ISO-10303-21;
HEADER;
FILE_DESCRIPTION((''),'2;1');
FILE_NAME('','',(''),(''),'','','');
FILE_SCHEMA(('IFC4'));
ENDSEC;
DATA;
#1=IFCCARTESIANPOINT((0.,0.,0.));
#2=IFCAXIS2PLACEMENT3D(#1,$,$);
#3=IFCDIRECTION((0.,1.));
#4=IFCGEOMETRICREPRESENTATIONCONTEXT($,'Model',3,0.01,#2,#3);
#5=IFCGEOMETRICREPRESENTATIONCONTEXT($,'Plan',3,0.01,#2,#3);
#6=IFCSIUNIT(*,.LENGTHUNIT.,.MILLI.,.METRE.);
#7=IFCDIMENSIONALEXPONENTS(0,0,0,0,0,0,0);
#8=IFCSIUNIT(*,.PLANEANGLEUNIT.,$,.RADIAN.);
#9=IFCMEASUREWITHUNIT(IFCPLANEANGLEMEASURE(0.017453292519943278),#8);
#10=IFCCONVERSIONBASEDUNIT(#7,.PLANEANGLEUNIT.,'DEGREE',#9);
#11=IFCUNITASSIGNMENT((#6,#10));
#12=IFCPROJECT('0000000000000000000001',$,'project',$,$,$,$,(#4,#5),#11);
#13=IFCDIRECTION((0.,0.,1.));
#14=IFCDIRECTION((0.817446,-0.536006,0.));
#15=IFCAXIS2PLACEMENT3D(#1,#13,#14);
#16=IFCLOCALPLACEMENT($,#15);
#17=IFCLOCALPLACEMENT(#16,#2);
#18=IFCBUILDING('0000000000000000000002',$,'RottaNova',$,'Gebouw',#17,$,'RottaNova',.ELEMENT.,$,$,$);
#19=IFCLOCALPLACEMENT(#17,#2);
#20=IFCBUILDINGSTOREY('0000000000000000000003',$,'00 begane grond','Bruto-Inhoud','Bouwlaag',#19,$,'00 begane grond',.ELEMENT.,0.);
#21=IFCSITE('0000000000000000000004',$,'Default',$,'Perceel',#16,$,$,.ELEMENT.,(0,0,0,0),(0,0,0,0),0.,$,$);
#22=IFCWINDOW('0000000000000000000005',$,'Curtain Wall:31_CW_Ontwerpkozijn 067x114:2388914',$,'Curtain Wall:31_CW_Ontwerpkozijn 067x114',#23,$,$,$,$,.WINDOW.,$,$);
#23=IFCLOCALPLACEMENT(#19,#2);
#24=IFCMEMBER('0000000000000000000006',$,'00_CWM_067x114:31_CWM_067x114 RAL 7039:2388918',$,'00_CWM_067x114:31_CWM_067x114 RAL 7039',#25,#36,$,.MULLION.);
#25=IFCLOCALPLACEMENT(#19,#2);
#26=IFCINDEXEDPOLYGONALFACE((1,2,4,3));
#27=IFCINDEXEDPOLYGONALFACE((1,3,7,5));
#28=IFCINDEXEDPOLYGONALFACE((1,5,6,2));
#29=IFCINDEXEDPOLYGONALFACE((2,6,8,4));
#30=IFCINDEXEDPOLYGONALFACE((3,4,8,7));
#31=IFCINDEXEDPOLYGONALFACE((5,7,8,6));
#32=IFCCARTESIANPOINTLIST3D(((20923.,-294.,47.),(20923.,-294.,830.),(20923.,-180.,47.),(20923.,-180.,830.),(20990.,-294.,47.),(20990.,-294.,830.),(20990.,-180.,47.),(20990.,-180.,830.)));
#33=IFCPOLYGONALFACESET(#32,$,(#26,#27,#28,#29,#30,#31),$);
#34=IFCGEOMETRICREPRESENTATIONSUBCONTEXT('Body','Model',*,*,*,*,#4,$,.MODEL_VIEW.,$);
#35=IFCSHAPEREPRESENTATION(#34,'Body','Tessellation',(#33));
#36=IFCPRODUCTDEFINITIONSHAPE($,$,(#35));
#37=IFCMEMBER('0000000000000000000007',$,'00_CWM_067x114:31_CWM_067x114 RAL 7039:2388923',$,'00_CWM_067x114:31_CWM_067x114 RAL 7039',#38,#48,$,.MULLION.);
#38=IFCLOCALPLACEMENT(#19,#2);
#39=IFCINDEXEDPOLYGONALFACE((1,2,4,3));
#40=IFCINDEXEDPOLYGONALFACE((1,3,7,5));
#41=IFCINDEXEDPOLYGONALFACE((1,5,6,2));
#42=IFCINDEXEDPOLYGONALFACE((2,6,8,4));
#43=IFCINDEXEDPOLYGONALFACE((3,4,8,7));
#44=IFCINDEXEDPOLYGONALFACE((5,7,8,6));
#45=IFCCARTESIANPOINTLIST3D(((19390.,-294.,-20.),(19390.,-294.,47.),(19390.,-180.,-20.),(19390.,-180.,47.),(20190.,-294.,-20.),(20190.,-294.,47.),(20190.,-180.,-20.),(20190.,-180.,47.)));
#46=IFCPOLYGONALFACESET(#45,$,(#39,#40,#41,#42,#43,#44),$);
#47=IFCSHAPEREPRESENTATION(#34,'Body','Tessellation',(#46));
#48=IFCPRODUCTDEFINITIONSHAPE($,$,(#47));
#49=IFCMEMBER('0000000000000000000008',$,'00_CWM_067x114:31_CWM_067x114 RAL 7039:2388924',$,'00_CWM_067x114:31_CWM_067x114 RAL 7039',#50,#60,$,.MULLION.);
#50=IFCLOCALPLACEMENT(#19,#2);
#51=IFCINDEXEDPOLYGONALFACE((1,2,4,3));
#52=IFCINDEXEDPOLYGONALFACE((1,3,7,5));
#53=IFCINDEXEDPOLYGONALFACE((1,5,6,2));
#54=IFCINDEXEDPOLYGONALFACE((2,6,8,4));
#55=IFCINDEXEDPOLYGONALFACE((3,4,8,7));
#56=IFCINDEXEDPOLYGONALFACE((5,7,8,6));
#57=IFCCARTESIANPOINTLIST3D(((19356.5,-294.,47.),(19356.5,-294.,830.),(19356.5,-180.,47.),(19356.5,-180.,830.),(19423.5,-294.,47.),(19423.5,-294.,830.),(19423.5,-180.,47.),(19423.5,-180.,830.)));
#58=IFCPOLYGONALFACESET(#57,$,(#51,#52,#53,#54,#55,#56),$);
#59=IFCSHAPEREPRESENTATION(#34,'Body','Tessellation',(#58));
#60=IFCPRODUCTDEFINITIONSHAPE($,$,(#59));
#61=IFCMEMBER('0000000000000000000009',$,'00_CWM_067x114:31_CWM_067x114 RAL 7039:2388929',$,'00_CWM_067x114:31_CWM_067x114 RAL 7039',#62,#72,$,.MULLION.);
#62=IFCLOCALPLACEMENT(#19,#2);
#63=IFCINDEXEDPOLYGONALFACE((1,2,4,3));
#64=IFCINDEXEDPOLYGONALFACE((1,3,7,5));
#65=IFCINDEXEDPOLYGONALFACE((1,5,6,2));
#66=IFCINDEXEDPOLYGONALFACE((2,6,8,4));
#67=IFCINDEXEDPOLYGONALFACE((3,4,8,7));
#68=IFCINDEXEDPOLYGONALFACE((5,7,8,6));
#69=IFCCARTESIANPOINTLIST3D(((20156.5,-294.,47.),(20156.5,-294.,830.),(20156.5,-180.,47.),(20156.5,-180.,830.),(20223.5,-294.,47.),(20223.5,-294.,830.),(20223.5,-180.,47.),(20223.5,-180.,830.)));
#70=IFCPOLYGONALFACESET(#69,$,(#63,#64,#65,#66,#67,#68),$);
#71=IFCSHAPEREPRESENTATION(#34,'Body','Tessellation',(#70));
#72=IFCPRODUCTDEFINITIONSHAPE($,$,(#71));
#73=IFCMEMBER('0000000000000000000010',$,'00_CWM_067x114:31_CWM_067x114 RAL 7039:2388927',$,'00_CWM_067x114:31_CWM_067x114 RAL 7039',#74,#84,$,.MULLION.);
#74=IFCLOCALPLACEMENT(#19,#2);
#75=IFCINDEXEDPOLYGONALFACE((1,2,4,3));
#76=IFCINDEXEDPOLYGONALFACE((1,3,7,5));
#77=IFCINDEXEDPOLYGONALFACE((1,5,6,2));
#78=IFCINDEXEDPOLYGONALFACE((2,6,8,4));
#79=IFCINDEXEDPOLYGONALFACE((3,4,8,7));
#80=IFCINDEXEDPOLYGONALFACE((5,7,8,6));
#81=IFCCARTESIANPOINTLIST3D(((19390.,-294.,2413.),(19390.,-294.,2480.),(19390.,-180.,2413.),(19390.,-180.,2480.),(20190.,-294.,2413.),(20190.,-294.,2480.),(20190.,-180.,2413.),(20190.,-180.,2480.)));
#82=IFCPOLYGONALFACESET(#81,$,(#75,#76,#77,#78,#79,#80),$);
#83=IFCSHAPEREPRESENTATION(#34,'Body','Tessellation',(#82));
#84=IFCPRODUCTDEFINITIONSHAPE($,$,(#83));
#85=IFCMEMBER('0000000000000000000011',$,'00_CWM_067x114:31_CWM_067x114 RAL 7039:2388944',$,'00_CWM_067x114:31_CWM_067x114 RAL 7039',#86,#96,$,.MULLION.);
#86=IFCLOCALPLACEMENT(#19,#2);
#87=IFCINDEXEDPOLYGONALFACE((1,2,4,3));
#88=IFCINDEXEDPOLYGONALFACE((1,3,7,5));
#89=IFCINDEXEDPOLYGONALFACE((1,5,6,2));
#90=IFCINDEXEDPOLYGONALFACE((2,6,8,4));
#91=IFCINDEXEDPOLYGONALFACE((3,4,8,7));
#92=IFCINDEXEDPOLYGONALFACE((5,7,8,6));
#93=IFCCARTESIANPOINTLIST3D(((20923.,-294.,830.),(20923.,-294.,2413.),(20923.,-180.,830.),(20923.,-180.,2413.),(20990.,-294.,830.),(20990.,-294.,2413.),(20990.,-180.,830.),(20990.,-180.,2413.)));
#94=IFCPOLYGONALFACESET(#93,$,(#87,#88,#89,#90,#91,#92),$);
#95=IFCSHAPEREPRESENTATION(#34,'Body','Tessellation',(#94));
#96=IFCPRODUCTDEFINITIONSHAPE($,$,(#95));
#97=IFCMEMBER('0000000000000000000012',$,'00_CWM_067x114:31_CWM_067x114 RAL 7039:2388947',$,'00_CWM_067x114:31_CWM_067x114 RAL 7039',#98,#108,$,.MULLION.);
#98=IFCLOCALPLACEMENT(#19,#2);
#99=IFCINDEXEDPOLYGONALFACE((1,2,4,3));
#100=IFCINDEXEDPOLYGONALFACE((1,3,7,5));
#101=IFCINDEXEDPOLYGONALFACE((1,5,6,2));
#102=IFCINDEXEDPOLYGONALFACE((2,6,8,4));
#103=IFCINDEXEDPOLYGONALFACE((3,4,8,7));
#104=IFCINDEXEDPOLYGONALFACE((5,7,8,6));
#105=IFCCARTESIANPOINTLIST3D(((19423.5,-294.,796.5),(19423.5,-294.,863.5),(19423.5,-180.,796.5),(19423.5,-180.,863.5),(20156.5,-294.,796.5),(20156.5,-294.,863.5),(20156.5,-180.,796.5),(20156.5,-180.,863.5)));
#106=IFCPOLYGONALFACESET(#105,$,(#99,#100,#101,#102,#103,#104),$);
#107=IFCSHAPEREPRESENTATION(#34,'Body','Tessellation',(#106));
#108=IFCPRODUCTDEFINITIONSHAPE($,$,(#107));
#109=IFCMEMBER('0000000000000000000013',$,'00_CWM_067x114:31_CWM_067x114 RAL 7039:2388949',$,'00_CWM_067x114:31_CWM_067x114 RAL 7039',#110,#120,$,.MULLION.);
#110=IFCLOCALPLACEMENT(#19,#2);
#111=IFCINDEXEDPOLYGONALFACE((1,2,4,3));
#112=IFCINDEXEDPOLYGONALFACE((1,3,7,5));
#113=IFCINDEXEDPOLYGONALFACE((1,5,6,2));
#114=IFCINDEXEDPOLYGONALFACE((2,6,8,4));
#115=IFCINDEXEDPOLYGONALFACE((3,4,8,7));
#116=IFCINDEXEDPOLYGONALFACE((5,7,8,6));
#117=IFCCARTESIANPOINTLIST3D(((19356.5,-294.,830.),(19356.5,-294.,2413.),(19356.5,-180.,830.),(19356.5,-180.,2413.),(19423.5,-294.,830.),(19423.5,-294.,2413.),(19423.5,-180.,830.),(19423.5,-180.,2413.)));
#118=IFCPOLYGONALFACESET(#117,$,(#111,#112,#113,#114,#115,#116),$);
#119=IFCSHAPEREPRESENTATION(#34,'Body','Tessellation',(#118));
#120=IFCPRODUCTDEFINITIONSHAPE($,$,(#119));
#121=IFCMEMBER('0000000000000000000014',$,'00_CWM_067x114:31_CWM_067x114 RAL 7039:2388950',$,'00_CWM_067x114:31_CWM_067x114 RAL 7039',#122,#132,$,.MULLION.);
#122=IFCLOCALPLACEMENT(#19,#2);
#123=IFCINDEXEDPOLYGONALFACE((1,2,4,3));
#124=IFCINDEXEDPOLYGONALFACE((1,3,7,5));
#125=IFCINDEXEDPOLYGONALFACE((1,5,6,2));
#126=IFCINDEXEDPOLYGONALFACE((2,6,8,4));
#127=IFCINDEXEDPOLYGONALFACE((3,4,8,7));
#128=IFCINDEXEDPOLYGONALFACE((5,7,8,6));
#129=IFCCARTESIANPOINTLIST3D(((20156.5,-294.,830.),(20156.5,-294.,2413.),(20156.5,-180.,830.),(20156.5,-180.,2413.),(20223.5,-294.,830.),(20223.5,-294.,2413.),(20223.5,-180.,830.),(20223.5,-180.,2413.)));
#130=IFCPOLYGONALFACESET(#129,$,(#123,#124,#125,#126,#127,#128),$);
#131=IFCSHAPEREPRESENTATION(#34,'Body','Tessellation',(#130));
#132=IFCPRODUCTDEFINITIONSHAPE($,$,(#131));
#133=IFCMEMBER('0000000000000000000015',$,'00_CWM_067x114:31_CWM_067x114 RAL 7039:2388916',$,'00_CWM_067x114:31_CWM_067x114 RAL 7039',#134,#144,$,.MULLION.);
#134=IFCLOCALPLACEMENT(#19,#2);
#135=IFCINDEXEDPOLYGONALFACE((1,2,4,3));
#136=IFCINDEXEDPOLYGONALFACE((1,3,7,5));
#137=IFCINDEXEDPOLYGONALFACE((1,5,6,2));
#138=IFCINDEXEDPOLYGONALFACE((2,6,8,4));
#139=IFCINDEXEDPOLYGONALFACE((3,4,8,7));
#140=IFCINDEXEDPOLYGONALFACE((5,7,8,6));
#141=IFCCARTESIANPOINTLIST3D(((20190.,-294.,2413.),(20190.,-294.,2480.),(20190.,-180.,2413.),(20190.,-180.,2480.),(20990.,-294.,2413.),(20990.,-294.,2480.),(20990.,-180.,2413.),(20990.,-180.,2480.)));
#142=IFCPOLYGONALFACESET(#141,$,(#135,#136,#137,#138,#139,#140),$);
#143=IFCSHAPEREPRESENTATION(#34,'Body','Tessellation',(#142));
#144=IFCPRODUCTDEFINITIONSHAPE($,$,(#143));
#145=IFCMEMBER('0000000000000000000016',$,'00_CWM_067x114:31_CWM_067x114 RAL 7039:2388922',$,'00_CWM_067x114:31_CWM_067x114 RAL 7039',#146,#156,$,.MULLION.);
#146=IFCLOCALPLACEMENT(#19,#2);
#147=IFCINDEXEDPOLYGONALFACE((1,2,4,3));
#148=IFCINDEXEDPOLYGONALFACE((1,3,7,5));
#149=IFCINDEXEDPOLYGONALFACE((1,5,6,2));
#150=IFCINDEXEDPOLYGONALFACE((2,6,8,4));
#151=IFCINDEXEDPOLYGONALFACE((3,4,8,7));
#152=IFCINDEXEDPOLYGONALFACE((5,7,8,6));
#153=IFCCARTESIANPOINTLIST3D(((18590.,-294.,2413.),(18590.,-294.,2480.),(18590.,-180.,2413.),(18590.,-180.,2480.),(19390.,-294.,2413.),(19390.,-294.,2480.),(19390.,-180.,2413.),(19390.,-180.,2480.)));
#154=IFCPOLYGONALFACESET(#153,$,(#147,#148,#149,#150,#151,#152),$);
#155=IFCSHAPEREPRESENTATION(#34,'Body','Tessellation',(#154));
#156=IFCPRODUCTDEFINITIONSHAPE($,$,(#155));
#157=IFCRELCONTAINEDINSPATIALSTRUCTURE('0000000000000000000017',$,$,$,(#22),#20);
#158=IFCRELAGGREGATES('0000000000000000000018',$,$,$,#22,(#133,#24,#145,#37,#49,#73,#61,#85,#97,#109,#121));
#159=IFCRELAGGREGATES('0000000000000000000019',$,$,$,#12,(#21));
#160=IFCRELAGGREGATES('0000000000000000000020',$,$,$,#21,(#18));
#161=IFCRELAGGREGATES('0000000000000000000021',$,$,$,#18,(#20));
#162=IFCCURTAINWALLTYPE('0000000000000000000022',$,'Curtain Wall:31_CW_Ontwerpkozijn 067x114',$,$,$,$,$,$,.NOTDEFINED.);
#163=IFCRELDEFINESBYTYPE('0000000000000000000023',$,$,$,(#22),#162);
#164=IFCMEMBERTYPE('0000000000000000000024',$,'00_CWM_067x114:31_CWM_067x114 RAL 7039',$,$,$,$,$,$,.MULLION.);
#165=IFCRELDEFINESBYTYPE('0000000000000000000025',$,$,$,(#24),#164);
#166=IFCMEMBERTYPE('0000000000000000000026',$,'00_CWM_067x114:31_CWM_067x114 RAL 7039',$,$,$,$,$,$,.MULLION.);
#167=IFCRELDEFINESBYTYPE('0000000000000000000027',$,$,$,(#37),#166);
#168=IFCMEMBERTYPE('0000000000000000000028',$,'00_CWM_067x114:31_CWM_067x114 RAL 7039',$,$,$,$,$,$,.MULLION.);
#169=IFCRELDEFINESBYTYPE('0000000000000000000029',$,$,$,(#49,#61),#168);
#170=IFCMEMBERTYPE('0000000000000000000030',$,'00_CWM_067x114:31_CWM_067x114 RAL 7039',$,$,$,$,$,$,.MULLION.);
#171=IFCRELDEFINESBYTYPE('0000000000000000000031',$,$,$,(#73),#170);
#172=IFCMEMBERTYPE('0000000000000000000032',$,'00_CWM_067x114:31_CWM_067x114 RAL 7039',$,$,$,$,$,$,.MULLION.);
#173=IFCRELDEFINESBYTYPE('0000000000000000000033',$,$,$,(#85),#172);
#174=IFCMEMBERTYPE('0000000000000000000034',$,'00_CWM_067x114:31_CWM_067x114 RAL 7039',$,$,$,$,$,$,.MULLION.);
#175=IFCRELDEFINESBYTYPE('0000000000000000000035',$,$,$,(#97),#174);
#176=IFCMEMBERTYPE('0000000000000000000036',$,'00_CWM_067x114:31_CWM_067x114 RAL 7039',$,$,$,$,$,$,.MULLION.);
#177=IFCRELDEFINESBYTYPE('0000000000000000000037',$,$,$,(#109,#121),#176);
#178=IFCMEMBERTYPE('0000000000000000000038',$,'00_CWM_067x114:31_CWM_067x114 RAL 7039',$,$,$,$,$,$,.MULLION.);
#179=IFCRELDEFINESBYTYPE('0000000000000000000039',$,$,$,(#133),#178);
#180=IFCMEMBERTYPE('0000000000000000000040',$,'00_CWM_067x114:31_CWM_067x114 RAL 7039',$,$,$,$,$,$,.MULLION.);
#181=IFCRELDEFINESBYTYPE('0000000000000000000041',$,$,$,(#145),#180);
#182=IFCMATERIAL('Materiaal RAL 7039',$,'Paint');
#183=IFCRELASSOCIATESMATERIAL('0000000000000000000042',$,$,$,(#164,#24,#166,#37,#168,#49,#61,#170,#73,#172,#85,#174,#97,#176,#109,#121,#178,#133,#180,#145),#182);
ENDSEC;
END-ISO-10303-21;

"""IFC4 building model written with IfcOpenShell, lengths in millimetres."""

from ifc_helpers import new_model, entity, si_unit, converted_unit, direction, frame, origin, place, context, subcontext, project, spatial, indexed_curve, outline, extrude, source, transform, mapped, material, type_object, type_shapes, element, aggregate, save


model = new_model("IFC4")

# Units and contexts
model_context = context("Model", 3, precision=0.01, world=origin(), true_north=direction((0.0, 1.0)))
plan_context = context("Plan", 3, precision=0.01, world=origin(), true_north=direction((0.0, 1.0)))
body_context = subcontext(model_context, "Body", "Model", "MODEL_VIEW")
ifc_project = project(units=[si_unit("LENGTHUNIT", "METRE", prefix="MILLI"), converted_unit("PLANEANGLEUNIT", "DEGREE", entity("IfcPlaneAngleMeasure", 0.017453292519943278), si_unit("PLANEANGLEUNIT", "RADIAN"), dimensions=[0, 0, 0, 0, 0, 0, 0])], contexts=[model_context, plan_context])

# Site, building, storey
site_placement = place(None, frame((0.0, 0.0, 0.0), z_axis=(0.0, 0.0, 1.0), x_axis=(0.817446, -0.536006, 0.0)))
site = spatial("IfcSite", under=ifc_project, at=site_placement, Name="Default", ObjectType="Perceel", CompositionType="ELEMENT", RefLatitude=(0, 0, 0, 0), RefLongitude=(0, 0, 0, 0), RefElevation=0.0)
building_placement = place(site_placement, origin())
building = spatial("IfcBuilding", under=site, at=building_placement, Name="RottaNova", ObjectType="Gebouw", LongName="RottaNova", CompositionType="ELEMENT")
storey_placement = place(building_placement, origin())
storey = spatial("IfcBuildingStorey", under=building, at=storey_placement, Name="00 begane grond", Description="Bruto-Inhoud", ObjectType="Bouwlaag", LongName="00 begane grond", CompositionType="ELEMENT", Elevation=0.0)

# Window, members
curtain_wall_type = type_object("IfcCurtainWallType", Name="Curtain Wall:31_CW_Ontwerpkozijn 067x114", PredefinedType="NOTDEFINED")
window_1_placement = place(storey_placement, origin())
window_1 = element("IfcWindow", 1, at=window_1_placement, inside=storey, type_object=curtain_wall_type, Name="Curtain Wall:31_CW_Ontwerpkozijn 067x114:2388914", ObjectType="Curtain Wall:31_CW_Ontwerpkozijn 067x114", PredefinedType="WINDOW")
ifc_material_1 = material(Name="Materiaal RAL 7039", Category="Paint")
member_type_1 = type_object("IfcMemberType", Name="00_CWM_067x114:31_CWM_067x114 RAL 7039", PredefinedType="MULLION", material=ifc_material_1)
shared_shape_1 = source(origin(), body_context, "Body", "SweptSolid", [
    extrude(outline(indexed_curve([(-33.5, -57.0), (33.5, -57.0), (33.5, 57.0), (-33.5, 57.0), (-33.5, -57.0)], self_intersect=False)), frame((-33.5, 57.0, -783.0), z_axis=(0.0, 0.0, 1.0), x_axis=(-1.0, 0.0, 0.0)), (0.0, 0.0, 1.0), 783.0),
])
type_shapes(member_type_1, [shared_shape_1])
member_1_placement = place(window_1_placement, frame((20990.0, -180.0, 47.0), z_axis=(0.0, 0.0, -1.0), x_axis=(1.0, 0.0, 0.0)))
member_1 = element("IfcMember", 2, at=member_1_placement, type_object=member_type_1, material=ifc_material_1, Name="00_CWM_067x114:31_CWM_067x114 RAL 7039:2388918", ObjectType="00_CWM_067x114:31_CWM_067x114 RAL 7039", PredefinedType="MULLION", context=body_context, shape_type="MappedRepresentation", body=[
    mapped(shared_shape_1, transform((0.0, 0.0, 0.0), scale=1.0)),
])
member_type_2 = type_object("IfcMemberType", Name="00_CWM_067x114:31_CWM_067x114 RAL 7039", PredefinedType="MULLION", material=ifc_material_1)
shared_shape_2 = source(origin(), body_context, "Body", "SweptSolid", [
    extrude(outline(indexed_curve([(-33.5, -57.0), (33.5, -57.0), (33.5, 57.0), (-33.5, 57.0), (-33.5, -57.0)], self_intersect=False)), frame((-33.5, 57.0, -800.0), z_axis=(0.0, 0.0, 1.0), x_axis=(-1.0, 0.0, 0.0)), (0.0, 0.0, 1.0), 800.0),
])
type_shapes(member_type_2, [shared_shape_2])
member_2_placement = place(window_1_placement, frame((19390.0, -180.0, -20.0), z_axis=(-1.0, 0.0, 0.0), x_axis=(0.0, 0.0, -1.0)))
member_2 = element("IfcMember", 3, at=member_2_placement, type_object=member_type_2, material=ifc_material_1, Name="00_CWM_067x114:31_CWM_067x114 RAL 7039:2388923", ObjectType="00_CWM_067x114:31_CWM_067x114 RAL 7039", PredefinedType="MULLION", context=body_context, shape_type="MappedRepresentation", body=[
    mapped(shared_shape_2, transform((0.0, 0.0, 0.0), scale=1.0)),
])
member_type_3 = type_object("IfcMemberType", Name="00_CWM_067x114:31_CWM_067x114 RAL 7039", PredefinedType="MULLION", material=ifc_material_1)
shared_shape_3 = source(origin(), body_context, "Body", "SweptSolid", [
    extrude(outline(indexed_curve([(-33.5, -57.0), (33.5, -57.0), (33.5, 57.0), (-33.5, 57.0), (-33.5, -57.0)], self_intersect=False)), frame((0.0, 57.0, -783.0), z_axis=(0.0, 0.0, 1.0), x_axis=(-1.0, 0.0, 0.0)), (0.0, 0.0, 1.0), 783.0),
])
type_shapes(member_type_3, [shared_shape_3])
member_3_placement = place(window_1_placement, frame((19390.0, -180.0, 47.0), z_axis=(0.0, 0.0, -1.0), x_axis=(1.0, 0.0, 0.0)))
member_3 = element("IfcMember", 4, at=member_3_placement, type_object=member_type_3, material=ifc_material_1, Name="00_CWM_067x114:31_CWM_067x114 RAL 7039:2388924", ObjectType="00_CWM_067x114:31_CWM_067x114 RAL 7039", PredefinedType="MULLION", context=body_context, shape_type="MappedRepresentation", body=[
    mapped(shared_shape_3, transform((0.0, 0.0, 0.0), scale=1.0)),
])
member_4_placement = place(window_1_placement, frame((20190.0, -180.0, 47.0), z_axis=(0.0, 0.0, -1.0), x_axis=(1.0, 0.0, 0.0)))
member_4 = element("IfcMember", 5, at=member_4_placement, type_object=member_type_3, material=ifc_material_1, Name="00_CWM_067x114:31_CWM_067x114 RAL 7039:2388929", ObjectType="00_CWM_067x114:31_CWM_067x114 RAL 7039", PredefinedType="MULLION", context=body_context, shape_type="MappedRepresentation", body=[
    mapped(shared_shape_3, transform((0.0, 0.0, 0.0), scale=1.0)),
])
member_type_4 = type_object("IfcMemberType", Name="00_CWM_067x114:31_CWM_067x114 RAL 7039", PredefinedType="MULLION", material=ifc_material_1)
shared_shape_4 = source(origin(), body_context, "Body", "SweptSolid", [
    extrude(outline(indexed_curve([(-33.5, -57.0), (33.5, -57.0), (33.5, 57.0), (-33.5, 57.0), (-33.5, -57.0)], self_intersect=False)), frame((-33.5, 57.0, -800.0), z_axis=(0.0, 0.0, 1.0), x_axis=(-1.0, 0.0, 0.0)), (0.0, 0.0, 1.0), 800.0),
])
type_shapes(member_type_4, [shared_shape_4])
member_5_placement = place(window_1_placement, frame((20190.0, -180.0, 2480.0), z_axis=(1.0, 0.0, 0.0), x_axis=(0.0, 0.0, 1.0)))
member_5 = element("IfcMember", 6, at=member_5_placement, type_object=member_type_4, material=ifc_material_1, Name="00_CWM_067x114:31_CWM_067x114 RAL 7039:2388927", ObjectType="00_CWM_067x114:31_CWM_067x114 RAL 7039", PredefinedType="MULLION", context=body_context, shape_type="MappedRepresentation", body=[
    mapped(shared_shape_4, transform((0.0, 0.0, 0.0), scale=1.0)),
])
member_type_5 = type_object("IfcMemberType", Name="00_CWM_067x114:31_CWM_067x114 RAL 7039", PredefinedType="MULLION", material=ifc_material_1)
shared_shape_5 = source(origin(), body_context, "Body", "SweptSolid", [
    extrude(outline(indexed_curve([(-33.5, -57.0), (33.5, -57.0), (33.5, 57.0), (-33.5, 57.0), (-33.5, -57.0)], self_intersect=False)), frame((-33.5, 57.0, -1583.0), z_axis=(0.0, 0.0, 1.0), x_axis=(-1.0, 0.0, 0.0)), (0.0, 0.0, 1.0), 1583.0),
])
type_shapes(member_type_5, [shared_shape_5])
member_6_placement = place(window_1_placement, frame((20990.0, -180.0, 830.0), z_axis=(0.0, 0.0, -1.0), x_axis=(1.0, 0.0, 0.0)))
member_6 = element("IfcMember", 7, at=member_6_placement, type_object=member_type_5, material=ifc_material_1, Name="00_CWM_067x114:31_CWM_067x114 RAL 7039:2388944", ObjectType="00_CWM_067x114:31_CWM_067x114 RAL 7039", PredefinedType="MULLION", context=body_context, shape_type="MappedRepresentation", body=[
    mapped(shared_shape_5, transform((0.0, 0.0, 0.0), scale=1.0)),
])
member_type_6 = type_object("IfcMemberType", Name="00_CWM_067x114:31_CWM_067x114 RAL 7039", PredefinedType="MULLION", material=ifc_material_1)
shared_shape_6 = source(origin(), body_context, "Body", "SweptSolid", [
    extrude(outline(indexed_curve([(-33.5, -57.0), (33.5, -57.0), (33.5, 57.0), (-33.5, 57.0), (-33.5, -57.0)], self_intersect=False)), frame((0.0, 57.0, -733.0), z_axis=(0.0, 0.0, 1.0), x_axis=(-1.0, 0.0, 0.0)), (0.0, 0.0, 1.0), 733.0),
])
type_shapes(member_type_6, [shared_shape_6])
member_7_placement = place(window_1_placement, frame((20156.5, -180.0, 830.0), z_axis=(1.0, 0.0, 0.0), x_axis=(0.0, 0.0, 1.0)))
member_7 = element("IfcMember", 8, at=member_7_placement, type_object=member_type_6, material=ifc_material_1, Name="00_CWM_067x114:31_CWM_067x114 RAL 7039:2388947", ObjectType="00_CWM_067x114:31_CWM_067x114 RAL 7039", PredefinedType="MULLION", context=body_context, shape_type="MappedRepresentation", body=[
    mapped(shared_shape_6, transform((0.0, 0.0, 0.0), scale=1.0)),
])
member_type_7 = type_object("IfcMemberType", Name="00_CWM_067x114:31_CWM_067x114 RAL 7039", PredefinedType="MULLION", material=ifc_material_1)
shared_shape_7 = source(origin(), body_context, "Body", "SweptSolid", [
    extrude(outline(indexed_curve([(-33.5, -57.0), (33.5, -57.0), (33.5, 57.0), (-33.5, 57.0), (-33.5, -57.0)], self_intersect=False)), frame((0.0, 57.0, -1583.0), z_axis=(0.0, 0.0, 1.0), x_axis=(-1.0, 0.0, 0.0)), (0.0, 0.0, 1.0), 1583.0),
])
type_shapes(member_type_7, [shared_shape_7])
member_8_placement = place(window_1_placement, frame((19390.0, -180.0, 830.0), z_axis=(0.0, 0.0, -1.0), x_axis=(1.0, 0.0, 0.0)))
member_8 = element("IfcMember", 9, at=member_8_placement, type_object=member_type_7, material=ifc_material_1, Name="00_CWM_067x114:31_CWM_067x114 RAL 7039:2388949", ObjectType="00_CWM_067x114:31_CWM_067x114 RAL 7039", PredefinedType="MULLION", context=body_context, shape_type="MappedRepresentation", body=[
    mapped(shared_shape_7, transform((0.0, 0.0, 0.0), scale=1.0)),
])
member_9_placement = place(window_1_placement, frame((20190.0, -180.0, 830.0), z_axis=(0.0, 0.0, -1.0), x_axis=(1.0, 0.0, 0.0)))
member_9 = element("IfcMember", 10, at=member_9_placement, type_object=member_type_7, material=ifc_material_1, Name="00_CWM_067x114:31_CWM_067x114 RAL 7039:2388950", ObjectType="00_CWM_067x114:31_CWM_067x114 RAL 7039", PredefinedType="MULLION", context=body_context, shape_type="MappedRepresentation", body=[
    mapped(shared_shape_7, transform((0.0, 0.0, 0.0), scale=1.0)),
])
member_type_8 = type_object("IfcMemberType", Name="00_CWM_067x114:31_CWM_067x114 RAL 7039", PredefinedType="MULLION", material=ifc_material_1)
shared_shape_8 = source(origin(), body_context, "Body", "SweptSolid", [
    extrude(outline(indexed_curve([(-33.5, -57.0), (33.5, -57.0), (33.5, 57.0), (-33.5, 57.0), (-33.5, -57.0)], self_intersect=False)), frame((-33.5, 57.0, -800.0), z_axis=(0.0, 0.0, 1.0), x_axis=(-1.0, 0.0, 0.0)), (0.0, 0.0, 1.0), 800.0),
])
type_shapes(member_type_8, [shared_shape_8])
member_10_placement = place(window_1_placement, frame((20990.0, -180.0, 2480.0), z_axis=(1.0, 0.0, 0.0), x_axis=(0.0, 0.0, 1.0)))
member_10 = element("IfcMember", 11, at=member_10_placement, type_object=member_type_8, material=ifc_material_1, Name="00_CWM_067x114:31_CWM_067x114 RAL 7039:2388916", ObjectType="00_CWM_067x114:31_CWM_067x114 RAL 7039", PredefinedType="MULLION", context=body_context, shape_type="MappedRepresentation", body=[
    mapped(shared_shape_8, transform((0.0, 0.0, 0.0), scale=1.0)),
])
member_type_9 = type_object("IfcMemberType", Name="00_CWM_067x114:31_CWM_067x114 RAL 7039", PredefinedType="MULLION", material=ifc_material_1)
shared_shape_9 = source(origin(), body_context, "Body", "SweptSolid", [
    extrude(outline(indexed_curve([(-33.5, -57.0), (33.5, -57.0), (33.5, 57.0), (-33.5, 57.0), (-33.5, -57.0)], self_intersect=False)), frame((-33.5, 57.0, -800.0), z_axis=(0.0, 0.0, 1.0), x_axis=(-1.0, 0.0, 0.0)), (0.0, 0.0, 1.0), 800.0),
])
type_shapes(member_type_9, [shared_shape_9])
member_11_placement = place(window_1_placement, frame((19390.0, -180.0, 2480.0), z_axis=(1.0, 0.0, 0.0), x_axis=(0.0, 0.0, 1.0)))
member_11 = element("IfcMember", 12, at=member_11_placement, type_object=member_type_9, material=ifc_material_1, Name="00_CWM_067x114:31_CWM_067x114 RAL 7039:2388922", ObjectType="00_CWM_067x114:31_CWM_067x114 RAL 7039", PredefinedType="MULLION", context=body_context, shape_type="MappedRepresentation", body=[
    mapped(shared_shape_9, transform((0.0, 0.0, 0.0), scale=1.0)),
])
aggregate(window_1, [member_10, member_1, member_11, member_2, member_3, member_5, member_4, member_6, member_7, member_8, member_9])

save(model, "model.ifc")
